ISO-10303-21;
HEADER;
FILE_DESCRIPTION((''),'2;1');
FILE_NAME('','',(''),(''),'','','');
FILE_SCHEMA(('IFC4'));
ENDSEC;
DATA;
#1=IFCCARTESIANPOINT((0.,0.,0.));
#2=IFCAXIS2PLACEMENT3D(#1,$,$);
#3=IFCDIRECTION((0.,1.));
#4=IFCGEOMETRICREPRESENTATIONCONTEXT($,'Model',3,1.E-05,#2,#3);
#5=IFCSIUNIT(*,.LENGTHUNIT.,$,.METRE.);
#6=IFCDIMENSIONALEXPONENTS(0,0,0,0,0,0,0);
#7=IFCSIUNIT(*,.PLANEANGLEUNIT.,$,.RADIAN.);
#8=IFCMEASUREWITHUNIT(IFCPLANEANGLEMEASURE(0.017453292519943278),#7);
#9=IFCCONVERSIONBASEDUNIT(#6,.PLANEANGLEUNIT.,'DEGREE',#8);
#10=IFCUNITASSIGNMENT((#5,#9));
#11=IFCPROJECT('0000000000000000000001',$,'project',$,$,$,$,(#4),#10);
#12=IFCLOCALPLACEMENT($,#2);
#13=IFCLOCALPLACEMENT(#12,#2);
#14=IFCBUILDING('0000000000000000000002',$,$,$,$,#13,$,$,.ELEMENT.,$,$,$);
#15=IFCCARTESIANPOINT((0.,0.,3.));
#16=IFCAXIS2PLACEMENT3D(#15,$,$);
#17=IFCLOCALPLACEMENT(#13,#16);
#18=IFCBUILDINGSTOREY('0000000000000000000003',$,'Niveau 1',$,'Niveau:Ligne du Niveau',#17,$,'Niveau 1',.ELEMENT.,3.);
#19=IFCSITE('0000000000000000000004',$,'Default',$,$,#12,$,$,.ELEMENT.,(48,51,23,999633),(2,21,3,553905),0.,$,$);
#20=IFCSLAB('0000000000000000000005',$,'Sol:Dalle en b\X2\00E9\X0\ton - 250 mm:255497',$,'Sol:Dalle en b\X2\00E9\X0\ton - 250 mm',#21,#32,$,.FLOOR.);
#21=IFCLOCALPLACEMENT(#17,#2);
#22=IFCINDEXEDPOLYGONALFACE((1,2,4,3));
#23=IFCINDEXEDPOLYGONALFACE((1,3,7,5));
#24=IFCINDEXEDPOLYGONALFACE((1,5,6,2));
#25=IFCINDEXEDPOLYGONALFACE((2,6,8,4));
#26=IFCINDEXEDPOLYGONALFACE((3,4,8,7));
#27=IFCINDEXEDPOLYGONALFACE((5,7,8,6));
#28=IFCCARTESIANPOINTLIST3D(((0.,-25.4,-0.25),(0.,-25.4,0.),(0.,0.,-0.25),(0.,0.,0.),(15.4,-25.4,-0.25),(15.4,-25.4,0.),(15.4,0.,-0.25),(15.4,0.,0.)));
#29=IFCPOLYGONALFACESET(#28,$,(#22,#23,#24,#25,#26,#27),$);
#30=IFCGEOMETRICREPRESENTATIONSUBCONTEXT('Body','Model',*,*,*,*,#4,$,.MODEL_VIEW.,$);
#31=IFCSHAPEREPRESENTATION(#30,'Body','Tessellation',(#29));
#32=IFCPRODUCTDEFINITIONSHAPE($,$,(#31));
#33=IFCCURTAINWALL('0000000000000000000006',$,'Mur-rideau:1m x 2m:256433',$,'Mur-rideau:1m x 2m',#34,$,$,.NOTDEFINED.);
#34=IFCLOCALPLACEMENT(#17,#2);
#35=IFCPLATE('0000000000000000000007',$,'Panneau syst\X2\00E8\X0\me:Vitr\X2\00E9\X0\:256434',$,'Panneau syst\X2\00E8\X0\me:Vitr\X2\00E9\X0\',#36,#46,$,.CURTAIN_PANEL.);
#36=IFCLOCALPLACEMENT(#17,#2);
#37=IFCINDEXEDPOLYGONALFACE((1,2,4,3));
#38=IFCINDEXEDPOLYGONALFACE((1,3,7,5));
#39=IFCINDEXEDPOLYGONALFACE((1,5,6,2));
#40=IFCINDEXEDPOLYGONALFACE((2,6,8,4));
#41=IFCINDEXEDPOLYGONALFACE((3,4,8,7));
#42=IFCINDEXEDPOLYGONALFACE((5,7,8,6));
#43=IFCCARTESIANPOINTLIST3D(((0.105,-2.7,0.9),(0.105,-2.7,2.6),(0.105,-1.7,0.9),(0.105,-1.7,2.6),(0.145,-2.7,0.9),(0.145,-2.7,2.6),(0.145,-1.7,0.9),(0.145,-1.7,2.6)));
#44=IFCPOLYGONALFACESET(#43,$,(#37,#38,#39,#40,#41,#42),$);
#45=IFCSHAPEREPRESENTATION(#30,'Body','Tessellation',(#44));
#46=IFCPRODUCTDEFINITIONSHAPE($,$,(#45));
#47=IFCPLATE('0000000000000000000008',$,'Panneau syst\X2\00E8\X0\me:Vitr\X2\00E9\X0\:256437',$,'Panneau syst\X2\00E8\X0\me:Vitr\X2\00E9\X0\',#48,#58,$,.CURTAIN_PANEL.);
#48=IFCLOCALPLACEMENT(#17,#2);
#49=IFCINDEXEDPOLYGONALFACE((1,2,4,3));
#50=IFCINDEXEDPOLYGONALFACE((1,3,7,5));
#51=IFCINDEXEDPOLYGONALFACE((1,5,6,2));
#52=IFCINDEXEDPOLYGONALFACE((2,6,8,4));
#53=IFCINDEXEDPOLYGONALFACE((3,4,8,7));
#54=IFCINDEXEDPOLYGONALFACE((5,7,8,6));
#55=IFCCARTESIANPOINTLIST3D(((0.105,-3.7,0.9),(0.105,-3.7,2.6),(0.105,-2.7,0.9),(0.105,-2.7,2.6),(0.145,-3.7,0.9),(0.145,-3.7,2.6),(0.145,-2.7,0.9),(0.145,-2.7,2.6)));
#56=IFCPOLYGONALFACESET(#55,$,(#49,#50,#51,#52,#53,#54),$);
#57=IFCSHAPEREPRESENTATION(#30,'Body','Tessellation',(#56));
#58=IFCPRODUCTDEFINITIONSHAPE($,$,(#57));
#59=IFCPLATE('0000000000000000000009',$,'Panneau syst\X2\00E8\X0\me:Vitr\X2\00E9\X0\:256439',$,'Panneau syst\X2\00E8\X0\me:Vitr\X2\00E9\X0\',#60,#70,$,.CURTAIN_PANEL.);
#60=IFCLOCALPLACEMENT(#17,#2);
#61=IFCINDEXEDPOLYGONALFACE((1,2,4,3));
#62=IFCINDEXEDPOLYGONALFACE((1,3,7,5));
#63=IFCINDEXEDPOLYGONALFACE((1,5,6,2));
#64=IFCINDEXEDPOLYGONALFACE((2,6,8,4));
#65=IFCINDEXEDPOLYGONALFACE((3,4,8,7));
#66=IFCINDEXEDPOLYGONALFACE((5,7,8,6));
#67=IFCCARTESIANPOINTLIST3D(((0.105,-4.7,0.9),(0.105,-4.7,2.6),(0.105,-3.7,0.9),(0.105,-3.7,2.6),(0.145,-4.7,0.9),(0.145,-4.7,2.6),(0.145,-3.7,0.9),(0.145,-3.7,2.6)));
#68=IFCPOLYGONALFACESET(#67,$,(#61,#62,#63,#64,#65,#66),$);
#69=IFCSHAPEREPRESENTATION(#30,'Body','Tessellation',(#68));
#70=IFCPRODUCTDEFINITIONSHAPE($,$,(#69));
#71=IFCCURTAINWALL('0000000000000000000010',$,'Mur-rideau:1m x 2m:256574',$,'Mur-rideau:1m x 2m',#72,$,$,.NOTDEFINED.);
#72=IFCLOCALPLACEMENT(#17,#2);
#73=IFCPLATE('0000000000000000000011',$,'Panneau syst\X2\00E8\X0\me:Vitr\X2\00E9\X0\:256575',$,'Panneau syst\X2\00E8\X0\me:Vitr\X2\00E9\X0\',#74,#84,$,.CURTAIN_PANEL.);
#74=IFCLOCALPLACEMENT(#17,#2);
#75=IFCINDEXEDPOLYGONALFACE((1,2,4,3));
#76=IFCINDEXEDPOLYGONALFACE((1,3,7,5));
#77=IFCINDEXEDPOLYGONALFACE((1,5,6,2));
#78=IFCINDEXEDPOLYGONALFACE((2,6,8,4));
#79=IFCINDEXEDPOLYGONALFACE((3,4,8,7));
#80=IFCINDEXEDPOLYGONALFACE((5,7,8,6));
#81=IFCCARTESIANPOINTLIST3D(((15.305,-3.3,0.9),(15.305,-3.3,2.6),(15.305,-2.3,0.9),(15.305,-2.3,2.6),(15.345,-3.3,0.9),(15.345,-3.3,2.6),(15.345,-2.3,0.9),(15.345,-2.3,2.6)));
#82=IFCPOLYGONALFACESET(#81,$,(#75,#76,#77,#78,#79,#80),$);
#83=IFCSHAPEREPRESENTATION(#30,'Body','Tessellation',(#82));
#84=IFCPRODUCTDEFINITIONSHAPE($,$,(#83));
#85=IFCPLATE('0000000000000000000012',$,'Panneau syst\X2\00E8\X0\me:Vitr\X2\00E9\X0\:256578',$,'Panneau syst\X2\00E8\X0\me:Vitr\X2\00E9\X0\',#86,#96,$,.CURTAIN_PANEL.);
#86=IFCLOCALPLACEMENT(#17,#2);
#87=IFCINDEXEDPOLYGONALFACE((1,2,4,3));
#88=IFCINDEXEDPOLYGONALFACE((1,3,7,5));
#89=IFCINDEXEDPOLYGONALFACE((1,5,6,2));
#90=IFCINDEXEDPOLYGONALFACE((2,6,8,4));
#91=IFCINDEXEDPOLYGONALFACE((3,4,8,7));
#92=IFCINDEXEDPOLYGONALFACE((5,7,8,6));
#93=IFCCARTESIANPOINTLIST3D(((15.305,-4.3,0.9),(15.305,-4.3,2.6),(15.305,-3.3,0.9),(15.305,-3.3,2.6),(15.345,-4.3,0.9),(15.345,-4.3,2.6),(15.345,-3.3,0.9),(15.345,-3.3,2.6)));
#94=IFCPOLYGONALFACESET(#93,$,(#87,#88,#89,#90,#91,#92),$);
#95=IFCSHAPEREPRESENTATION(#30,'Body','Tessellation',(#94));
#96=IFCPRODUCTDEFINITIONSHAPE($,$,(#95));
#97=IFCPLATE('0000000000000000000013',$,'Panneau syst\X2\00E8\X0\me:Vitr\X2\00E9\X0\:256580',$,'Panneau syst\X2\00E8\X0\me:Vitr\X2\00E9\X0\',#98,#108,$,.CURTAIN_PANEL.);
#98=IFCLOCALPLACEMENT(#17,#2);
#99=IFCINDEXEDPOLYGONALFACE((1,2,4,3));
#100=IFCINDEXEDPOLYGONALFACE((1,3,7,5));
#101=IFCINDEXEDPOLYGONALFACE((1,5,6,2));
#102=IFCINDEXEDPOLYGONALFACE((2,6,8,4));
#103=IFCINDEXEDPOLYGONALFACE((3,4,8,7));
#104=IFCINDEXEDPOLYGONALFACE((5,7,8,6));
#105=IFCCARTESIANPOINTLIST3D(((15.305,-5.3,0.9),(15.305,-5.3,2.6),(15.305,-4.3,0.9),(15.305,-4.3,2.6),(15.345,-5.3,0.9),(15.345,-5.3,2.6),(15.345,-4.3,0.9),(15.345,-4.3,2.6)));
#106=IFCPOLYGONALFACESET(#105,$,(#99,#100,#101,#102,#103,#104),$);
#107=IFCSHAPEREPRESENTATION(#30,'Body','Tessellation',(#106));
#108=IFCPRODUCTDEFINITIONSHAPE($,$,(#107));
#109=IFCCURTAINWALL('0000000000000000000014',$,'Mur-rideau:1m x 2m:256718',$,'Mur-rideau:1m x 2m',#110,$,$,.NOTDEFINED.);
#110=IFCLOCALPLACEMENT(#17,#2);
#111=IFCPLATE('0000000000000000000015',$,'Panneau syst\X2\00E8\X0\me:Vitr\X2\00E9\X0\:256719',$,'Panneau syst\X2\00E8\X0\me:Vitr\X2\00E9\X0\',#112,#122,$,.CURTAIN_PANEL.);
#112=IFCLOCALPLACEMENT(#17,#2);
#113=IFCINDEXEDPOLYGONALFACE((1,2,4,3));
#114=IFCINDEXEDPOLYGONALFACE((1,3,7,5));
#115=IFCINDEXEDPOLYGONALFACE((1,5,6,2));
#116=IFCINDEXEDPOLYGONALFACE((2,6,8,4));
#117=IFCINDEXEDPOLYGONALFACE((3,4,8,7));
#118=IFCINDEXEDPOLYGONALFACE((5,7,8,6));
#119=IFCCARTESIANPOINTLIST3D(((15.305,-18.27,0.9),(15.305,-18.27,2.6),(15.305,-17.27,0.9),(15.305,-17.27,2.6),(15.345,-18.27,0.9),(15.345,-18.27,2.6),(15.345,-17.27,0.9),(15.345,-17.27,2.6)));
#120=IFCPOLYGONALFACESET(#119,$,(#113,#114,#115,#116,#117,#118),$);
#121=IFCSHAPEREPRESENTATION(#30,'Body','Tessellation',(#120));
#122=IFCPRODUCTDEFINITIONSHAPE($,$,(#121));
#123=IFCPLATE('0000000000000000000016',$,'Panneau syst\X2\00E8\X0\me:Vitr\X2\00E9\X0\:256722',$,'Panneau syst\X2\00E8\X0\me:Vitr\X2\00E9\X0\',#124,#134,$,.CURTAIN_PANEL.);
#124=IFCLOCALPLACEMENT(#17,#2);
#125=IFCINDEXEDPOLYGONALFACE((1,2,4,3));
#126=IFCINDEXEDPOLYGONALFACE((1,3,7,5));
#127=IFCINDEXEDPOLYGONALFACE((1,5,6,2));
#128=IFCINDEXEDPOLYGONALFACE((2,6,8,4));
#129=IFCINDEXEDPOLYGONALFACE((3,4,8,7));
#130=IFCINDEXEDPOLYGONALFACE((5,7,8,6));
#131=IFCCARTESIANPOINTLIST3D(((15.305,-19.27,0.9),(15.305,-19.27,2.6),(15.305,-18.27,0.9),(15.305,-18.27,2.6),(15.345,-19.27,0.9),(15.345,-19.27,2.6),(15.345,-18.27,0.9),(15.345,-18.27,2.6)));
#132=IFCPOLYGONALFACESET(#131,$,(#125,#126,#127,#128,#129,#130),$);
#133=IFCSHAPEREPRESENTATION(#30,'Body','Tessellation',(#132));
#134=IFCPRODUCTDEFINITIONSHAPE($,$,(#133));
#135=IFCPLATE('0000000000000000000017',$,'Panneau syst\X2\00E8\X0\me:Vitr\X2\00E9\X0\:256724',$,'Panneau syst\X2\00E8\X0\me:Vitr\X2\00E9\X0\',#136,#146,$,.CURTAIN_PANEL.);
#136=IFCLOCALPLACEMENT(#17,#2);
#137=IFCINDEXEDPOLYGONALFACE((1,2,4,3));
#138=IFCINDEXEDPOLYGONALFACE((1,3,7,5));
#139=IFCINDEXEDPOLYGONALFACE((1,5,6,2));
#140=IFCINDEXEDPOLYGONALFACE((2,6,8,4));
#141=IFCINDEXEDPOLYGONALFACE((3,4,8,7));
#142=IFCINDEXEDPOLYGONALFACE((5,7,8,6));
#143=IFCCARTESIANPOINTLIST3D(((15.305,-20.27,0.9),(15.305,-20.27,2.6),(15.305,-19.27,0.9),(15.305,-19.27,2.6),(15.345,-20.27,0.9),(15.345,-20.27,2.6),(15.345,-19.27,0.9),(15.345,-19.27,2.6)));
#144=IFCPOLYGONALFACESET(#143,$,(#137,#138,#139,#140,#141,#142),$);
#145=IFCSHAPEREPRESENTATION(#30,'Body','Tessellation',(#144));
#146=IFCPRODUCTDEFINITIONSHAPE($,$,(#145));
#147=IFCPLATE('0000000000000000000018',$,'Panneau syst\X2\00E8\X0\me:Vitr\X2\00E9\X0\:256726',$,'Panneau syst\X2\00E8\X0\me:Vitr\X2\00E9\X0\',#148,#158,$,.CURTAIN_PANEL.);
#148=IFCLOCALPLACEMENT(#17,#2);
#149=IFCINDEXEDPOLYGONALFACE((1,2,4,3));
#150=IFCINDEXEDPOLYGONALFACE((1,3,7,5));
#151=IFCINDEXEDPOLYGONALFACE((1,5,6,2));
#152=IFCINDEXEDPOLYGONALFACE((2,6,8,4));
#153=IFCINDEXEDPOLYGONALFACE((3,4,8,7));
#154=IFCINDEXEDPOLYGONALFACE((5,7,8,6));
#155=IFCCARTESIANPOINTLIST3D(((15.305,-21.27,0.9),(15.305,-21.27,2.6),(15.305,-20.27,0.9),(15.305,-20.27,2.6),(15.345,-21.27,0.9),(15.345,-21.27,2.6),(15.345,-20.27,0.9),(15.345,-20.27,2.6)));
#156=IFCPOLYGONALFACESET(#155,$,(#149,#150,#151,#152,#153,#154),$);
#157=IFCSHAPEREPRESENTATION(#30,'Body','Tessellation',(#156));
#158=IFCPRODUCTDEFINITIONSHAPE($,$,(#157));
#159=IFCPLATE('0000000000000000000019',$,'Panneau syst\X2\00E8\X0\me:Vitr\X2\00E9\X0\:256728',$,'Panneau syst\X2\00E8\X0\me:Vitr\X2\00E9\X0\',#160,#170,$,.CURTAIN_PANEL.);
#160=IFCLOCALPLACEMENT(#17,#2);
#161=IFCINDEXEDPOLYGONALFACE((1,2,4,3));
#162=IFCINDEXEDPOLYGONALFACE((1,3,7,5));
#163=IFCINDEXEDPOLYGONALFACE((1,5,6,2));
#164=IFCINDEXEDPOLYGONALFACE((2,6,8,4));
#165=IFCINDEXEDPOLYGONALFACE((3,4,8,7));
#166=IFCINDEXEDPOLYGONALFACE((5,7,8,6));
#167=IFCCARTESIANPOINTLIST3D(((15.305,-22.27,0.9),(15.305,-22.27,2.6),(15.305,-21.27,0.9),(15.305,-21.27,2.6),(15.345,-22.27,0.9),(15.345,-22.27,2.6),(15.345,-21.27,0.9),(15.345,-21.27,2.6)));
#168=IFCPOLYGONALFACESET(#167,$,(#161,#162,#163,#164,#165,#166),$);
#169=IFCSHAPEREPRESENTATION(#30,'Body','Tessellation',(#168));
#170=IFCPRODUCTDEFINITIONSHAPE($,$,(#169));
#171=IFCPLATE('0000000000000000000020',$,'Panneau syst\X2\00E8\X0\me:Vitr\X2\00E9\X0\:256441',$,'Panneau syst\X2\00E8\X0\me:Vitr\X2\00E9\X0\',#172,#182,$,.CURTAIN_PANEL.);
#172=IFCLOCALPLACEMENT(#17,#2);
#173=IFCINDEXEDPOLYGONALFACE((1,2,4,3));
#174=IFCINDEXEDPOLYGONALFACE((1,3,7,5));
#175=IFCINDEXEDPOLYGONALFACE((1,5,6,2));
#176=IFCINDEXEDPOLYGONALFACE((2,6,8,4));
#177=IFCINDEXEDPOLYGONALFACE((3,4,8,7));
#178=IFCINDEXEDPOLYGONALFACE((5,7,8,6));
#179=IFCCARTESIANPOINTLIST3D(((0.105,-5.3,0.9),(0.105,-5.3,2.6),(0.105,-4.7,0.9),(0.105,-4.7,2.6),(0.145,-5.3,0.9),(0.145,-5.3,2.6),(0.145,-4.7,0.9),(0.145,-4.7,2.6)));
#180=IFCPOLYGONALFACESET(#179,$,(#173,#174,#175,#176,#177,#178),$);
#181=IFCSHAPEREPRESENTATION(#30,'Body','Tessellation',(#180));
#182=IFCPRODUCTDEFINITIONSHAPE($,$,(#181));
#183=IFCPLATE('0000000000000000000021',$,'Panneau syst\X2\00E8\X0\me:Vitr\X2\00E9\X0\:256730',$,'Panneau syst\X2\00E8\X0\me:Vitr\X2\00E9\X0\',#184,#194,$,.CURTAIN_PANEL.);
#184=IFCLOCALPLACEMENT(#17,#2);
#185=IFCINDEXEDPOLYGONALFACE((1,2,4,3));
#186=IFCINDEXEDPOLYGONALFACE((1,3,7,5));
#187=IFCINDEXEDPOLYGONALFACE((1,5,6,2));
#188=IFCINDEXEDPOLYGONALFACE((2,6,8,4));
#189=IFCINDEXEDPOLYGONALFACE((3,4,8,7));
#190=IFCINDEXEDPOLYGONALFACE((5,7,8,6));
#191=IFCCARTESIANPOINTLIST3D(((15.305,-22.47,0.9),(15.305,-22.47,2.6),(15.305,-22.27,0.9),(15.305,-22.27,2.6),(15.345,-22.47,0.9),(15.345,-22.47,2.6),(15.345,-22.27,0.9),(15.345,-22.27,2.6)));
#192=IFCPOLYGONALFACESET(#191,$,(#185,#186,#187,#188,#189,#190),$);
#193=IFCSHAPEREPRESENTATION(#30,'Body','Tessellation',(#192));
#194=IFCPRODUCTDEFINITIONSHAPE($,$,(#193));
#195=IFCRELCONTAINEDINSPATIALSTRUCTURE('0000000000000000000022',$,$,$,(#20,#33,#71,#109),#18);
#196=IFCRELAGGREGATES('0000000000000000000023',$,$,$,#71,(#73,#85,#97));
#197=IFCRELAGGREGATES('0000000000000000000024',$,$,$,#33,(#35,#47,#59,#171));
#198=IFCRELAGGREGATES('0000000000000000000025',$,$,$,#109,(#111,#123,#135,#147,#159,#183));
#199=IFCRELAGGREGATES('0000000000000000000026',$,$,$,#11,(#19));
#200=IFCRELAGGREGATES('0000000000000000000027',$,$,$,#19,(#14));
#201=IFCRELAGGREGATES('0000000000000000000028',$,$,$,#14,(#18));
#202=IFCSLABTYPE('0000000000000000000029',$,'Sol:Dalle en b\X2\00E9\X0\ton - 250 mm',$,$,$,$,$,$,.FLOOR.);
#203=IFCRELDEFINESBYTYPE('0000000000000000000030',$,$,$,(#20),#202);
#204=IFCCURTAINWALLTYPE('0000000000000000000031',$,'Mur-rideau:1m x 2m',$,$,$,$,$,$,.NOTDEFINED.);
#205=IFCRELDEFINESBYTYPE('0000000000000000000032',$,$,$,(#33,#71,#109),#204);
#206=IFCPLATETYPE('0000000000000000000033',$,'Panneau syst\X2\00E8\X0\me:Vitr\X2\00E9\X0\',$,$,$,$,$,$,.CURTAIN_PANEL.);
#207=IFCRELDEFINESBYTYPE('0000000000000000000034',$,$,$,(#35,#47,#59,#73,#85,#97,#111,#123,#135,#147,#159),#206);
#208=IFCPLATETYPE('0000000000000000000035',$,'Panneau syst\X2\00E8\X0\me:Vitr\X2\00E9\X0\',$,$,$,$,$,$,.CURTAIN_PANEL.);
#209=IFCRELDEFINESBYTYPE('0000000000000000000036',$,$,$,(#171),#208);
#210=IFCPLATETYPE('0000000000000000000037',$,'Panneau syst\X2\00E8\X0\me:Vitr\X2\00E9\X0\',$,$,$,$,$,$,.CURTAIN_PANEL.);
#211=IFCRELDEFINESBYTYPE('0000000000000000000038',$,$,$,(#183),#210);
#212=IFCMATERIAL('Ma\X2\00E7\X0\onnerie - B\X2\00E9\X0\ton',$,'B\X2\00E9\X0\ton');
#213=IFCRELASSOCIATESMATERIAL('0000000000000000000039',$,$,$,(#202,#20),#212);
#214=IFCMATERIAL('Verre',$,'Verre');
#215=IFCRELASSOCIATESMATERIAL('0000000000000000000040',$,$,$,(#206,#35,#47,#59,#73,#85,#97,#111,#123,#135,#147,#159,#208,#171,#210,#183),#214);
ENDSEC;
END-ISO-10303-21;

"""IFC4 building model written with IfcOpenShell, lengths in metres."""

from ifc_helpers import new_model, entity, si_unit, converted_unit, direction, frame, origin, place, context, subcontext, project, spatial, indexed_curve, outline, extrude, source, transform, mapped, material, type_object, type_shapes, element, aggregate, save


model = new_model("IFC4")

# Units and contexts
model_context = context("Model", 3, precision=1e-05, world=origin(), true_north=direction((0.0, 1.0)))
body_context = subcontext(model_context, "Body", "Model", "MODEL_VIEW")
ifc_project = project(units=[si_unit("LENGTHUNIT", "METRE"), converted_unit("PLANEANGLEUNIT", "DEGREE", entity("IfcPlaneAngleMeasure", 0.017453292519943278), si_unit("PLANEANGLEUNIT", "RADIAN"), dimensions=[0, 0, 0, 0, 0, 0, 0])], contexts=[model_context])

# Site, building, storey
site_placement = place(None, origin())
site = spatial("IfcSite", under=ifc_project, at=site_placement, Name="Default", CompositionType="ELEMENT", RefLatitude=(48, 51, 23, 999633), RefLongitude=(2, 21, 3, 553905), RefElevation=0.0)
building_placement = place(site_placement, origin())
building = spatial("IfcBuilding", under=site, at=building_placement, CompositionType="ELEMENT")
storey_placement = place(building_placement, frame((0.0, 0.0, 3.0)))
storey = spatial("IfcBuildingStorey", under=building, at=storey_placement, Name="Niveau 1", ObjectType="Niveau:Ligne du Niveau", LongName="Niveau 1", CompositionType="ELEMENT", Elevation=3.0)

# Slab
ifc_material_1 = material(Name="Maçonnerie - Béton", Category="Béton")
slab_type = type_object("IfcSlabType", Name="Sol:Dalle en béton - 250 mm", PredefinedType="FLOOR", material=ifc_material_1)
slab_placement = place(storey_placement, origin())
element("IfcSlab", 1, at=slab_placement, inside=storey, type_object=slab_type, material=ifc_material_1, Name="Sol:Dalle en béton - 250 mm:255497", ObjectType="Sol:Dalle en béton - 250 mm", PredefinedType="FLOOR", context=body_context, shape_type="SweptSolid", body=[
    extrude(outline(indexed_curve([(-12.7, -7.7), (12.7, -7.7), (12.7, 7.7), (-12.7, 7.7), (-12.7, -7.7)], self_intersect=False)), frame((7.7, -12.7, 0.0), z_axis=(0.0, 0.0, -1.0), x_axis=(0.0, 1.0, 0.0)), (0.0, 0.0, 1.0), 0.25),
])

# Curtain walls, plates
curtain_wall_type = type_object("IfcCurtainWallType", Name="Mur-rideau:1m x 2m", PredefinedType="NOTDEFINED")
curtain_wall_1_placement = place(storey_placement, frame((0.0, 0.0, -3.0)))
curtain_wall_1 = element("IfcCurtainWall", 2, at=curtain_wall_1_placement, inside=storey, type_object=curtain_wall_type, Name="Mur-rideau:1m x 2m:256433", ObjectType="Mur-rideau:1m x 2m", PredefinedType="NOTDEFINED")
ifc_material_2 = material(Name="Verre", Category="Verre")
plate_type_1 = type_object("IfcPlateType", Name="Panneau système:Vitré", PredefinedType="CURTAIN_PANEL", material=ifc_material_2)
shared_shape_1 = source(origin(), body_context, "Body", "SweptSolid", [
    extrude(outline(indexed_curve([(-0.02, -0.5), (0.02, -0.5), (0.02, 0.5), (-0.02, 0.5), (-0.02, -0.5)], self_intersect=False)), frame((0.5, 0.02, 0.0), z_axis=(0.0, 0.0, 1.0), x_axis=(0.0, 1.0, 0.0)), (0.0, 0.0, 1.0), 1.7),
])
type_shapes(plate_type_1, [shared_shape_1])
plate_1_placement = place(curtain_wall_1_placement, frame((0.105, -1.7, 3.9), z_axis=(0.0, 0.0, 1.0), x_axis=(0.0, -1.0, 0.0)))
plate_1 = element("IfcPlate", 3, at=plate_1_placement, type_object=plate_type_1, material=ifc_material_2, Name="Panneau système:Vitré:256434", ObjectType="Panneau système:Vitré", PredefinedType="CURTAIN_PANEL", context=body_context, shape_type="MappedRepresentation", body=[
    mapped(shared_shape_1, transform((0.0, 0.0, 0.0), scale=1.0)),
])
plate_2_placement = place(curtain_wall_1_placement, frame((0.105, -2.7, 3.9), z_axis=(0.0, 0.0, 1.0), x_axis=(0.0, -1.0, 0.0)))
plate_2 = element("IfcPlate", 4, at=plate_2_placement, type_object=plate_type_1, material=ifc_material_2, Name="Panneau système:Vitré:256437", ObjectType="Panneau système:Vitré", PredefinedType="CURTAIN_PANEL", context=body_context, shape_type="MappedRepresentation", body=[
    mapped(shared_shape_1, transform((0.0, 0.0, 0.0), scale=1.0)),
])
plate_3_placement = place(curtain_wall_1_placement, frame((0.105, -3.7, 3.9), z_axis=(0.0, 0.0, 1.0), x_axis=(0.0, -1.0, 0.0)))
plate_3 = element("IfcPlate", 5, at=plate_3_placement, type_object=plate_type_1, material=ifc_material_2, Name="Panneau système:Vitré:256439", ObjectType="Panneau système:Vitré", PredefinedType="CURTAIN_PANEL", context=body_context, shape_type="MappedRepresentation", body=[
    mapped(shared_shape_1, transform((0.0, 0.0, 0.0), scale=1.0)),
])
curtain_wall_2_placement = place(storey_placement, frame((0.0, 0.0, -3.0)))
curtain_wall_2 = element("IfcCurtainWall", 6, at=curtain_wall_2_placement, inside=storey, type_object=curtain_wall_type, Name="Mur-rideau:1m x 2m:256574", ObjectType="Mur-rideau:1m x 2m", PredefinedType="NOTDEFINED")
plate_4_placement = place(curtain_wall_2_placement, frame((15.305, -2.3, 3.9), z_axis=(0.0, 0.0, 1.0), x_axis=(0.0, -1.0, 0.0)))
plate_4 = element("IfcPlate", 7, at=plate_4_placement, type_object=plate_type_1, material=ifc_material_2, Name="Panneau système:Vitré:256575", ObjectType="Panneau système:Vitré", PredefinedType="CURTAIN_PANEL", context=body_context, shape_type="MappedRepresentation", body=[
    mapped(shared_shape_1, transform((0.0, 0.0, 0.0), scale=1.0)),
])
plate_5_placement = place(curtain_wall_2_placement, frame((15.305, -3.3, 3.9), z_axis=(0.0, 0.0, 1.0), x_axis=(0.0, -1.0, 0.0)))
plate_5 = element("IfcPlate", 8, at=plate_5_placement, type_object=plate_type_1, material=ifc_material_2, Name="Panneau système:Vitré:256578", ObjectType="Panneau système:Vitré", PredefinedType="CURTAIN_PANEL", context=body_context, shape_type="MappedRepresentation", body=[
    mapped(shared_shape_1, transform((0.0, 0.0, 0.0), scale=1.0)),
])
plate_6_placement = place(curtain_wall_2_placement, frame((15.305, -4.3, 3.9), z_axis=(0.0, 0.0, 1.0), x_axis=(0.0, -1.0, 0.0)))
plate_6 = element("IfcPlate", 9, at=plate_6_placement, type_object=plate_type_1, material=ifc_material_2, Name="Panneau système:Vitré:256580", ObjectType="Panneau système:Vitré", PredefinedType="CURTAIN_PANEL", context=body_context, shape_type="MappedRepresentation", body=[
    mapped(shared_shape_1, transform((0.0, 0.0, 0.0), scale=1.0)),
])
aggregate(curtain_wall_2, [plate_4, plate_5, plate_6])
curtain_wall_3_placement = place(storey_placement, frame((0.0, 0.0, -3.0)))
curtain_wall_3 = element("IfcCurtainWall", 10, at=curtain_wall_3_placement, inside=storey, type_object=curtain_wall_type, Name="Mur-rideau:1m x 2m:256718", ObjectType="Mur-rideau:1m x 2m", PredefinedType="NOTDEFINED")
plate_7_placement = place(curtain_wall_3_placement, frame((15.305, -17.27, 3.9), z_axis=(0.0, 0.0, 1.0), x_axis=(0.0, -1.0, 0.0)))
plate_7 = element("IfcPlate", 11, at=plate_7_placement, type_object=plate_type_1, material=ifc_material_2, Name="Panneau système:Vitré:256719", ObjectType="Panneau système:Vitré", PredefinedType="CURTAIN_PANEL", context=body_context, shape_type="MappedRepresentation", body=[
    mapped(shared_shape_1, transform((0.0, 0.0, 0.0), scale=1.0)),
])
plate_8_placement = place(curtain_wall_3_placement, frame((15.305, -18.27, 3.9), z_axis=(0.0, 0.0, 1.0), x_axis=(0.0, -1.0, 0.0)))
plate_8 = element("IfcPlate", 12, at=plate_8_placement, type_object=plate_type_1, material=ifc_material_2, Name="Panneau système:Vitré:256722", ObjectType="Panneau système:Vitré", PredefinedType="CURTAIN_PANEL", context=body_context, shape_type="MappedRepresentation", body=[
    mapped(shared_shape_1, transform((0.0, 0.0, 0.0), scale=1.0)),
])
plate_9_placement = place(curtain_wall_3_placement, frame((15.305, -19.27, 3.9), z_axis=(0.0, 0.0, 1.0), x_axis=(0.0, -1.0, 0.0)))
plate_9 = element("IfcPlate", 13, at=plate_9_placement, type_object=plate_type_1, material=ifc_material_2, Name="Panneau système:Vitré:256724", ObjectType="Panneau système:Vitré", PredefinedType="CURTAIN_PANEL", context=body_context, shape_type="MappedRepresentation", body=[
    mapped(shared_shape_1, transform((0.0, 0.0, 0.0), scale=1.0)),
])
plate_10_placement = place(curtain_wall_3_placement, frame((15.305, -20.27, 3.9), z_axis=(0.0, 0.0, 1.0), x_axis=(0.0, -1.0, 0.0)))
plate_10 = element("IfcPlate", 14, at=plate_10_placement, type_object=plate_type_1, material=ifc_material_2, Name="Panneau système:Vitré:256726", ObjectType="Panneau système:Vitré", PredefinedType="CURTAIN_PANEL", context=body_context, shape_type="MappedRepresentation", body=[
    mapped(shared_shape_1, transform((0.0, 0.0, 0.0), scale=1.0)),
])
plate_11_placement = place(curtain_wall_3_placement, frame((15.305, -21.27, 3.9), z_axis=(0.0, 0.0, 1.0), x_axis=(0.0, -1.0, 0.0)))
plate_11 = element("IfcPlate", 15, at=plate_11_placement, type_object=plate_type_1, material=ifc_material_2, Name="Panneau système:Vitré:256728", ObjectType="Panneau système:Vitré", PredefinedType="CURTAIN_PANEL", context=body_context, shape_type="MappedRepresentation", body=[
    mapped(shared_shape_1, transform((0.0, 0.0, 0.0), scale=1.0)),
])

# Plates
plate_type_2 = type_object("IfcPlateType", Name="Panneau système:Vitré", PredefinedType="CURTAIN_PANEL", material=ifc_material_2)
shared_shape_2 = source(origin(), body_context, "Body", "SweptSolid", [
    extrude(outline(indexed_curve([(-0.02, -0.3), (0.02, -0.3), (0.02, 0.3), (-0.02, 0.3), (-0.02, -0.3)], self_intersect=False)), frame((0.3, 0.02, 0.0), z_axis=(0.0, 0.0, 1.0), x_axis=(0.0, 1.0, 0.0)), (0.0, 0.0, 1.0), 1.7),
])
type_shapes(plate_type_2, [shared_shape_2])
plate_12_placement = place(curtain_wall_1_placement, frame((0.105, -4.7, 3.9), z_axis=(0.0, 0.0, 1.0), x_axis=(0.0, -1.0, 0.0)))
plate_12 = element("IfcPlate", 16, at=plate_12_placement, type_object=plate_type_2, material=ifc_material_2, Name="Panneau système:Vitré:256441", ObjectType="Panneau système:Vitré", PredefinedType="CURTAIN_PANEL", context=body_context, shape_type="MappedRepresentation", body=[
    mapped(shared_shape_2, transform((0.0, 0.0, 0.0), scale=1.0)),
])
aggregate(curtain_wall_1, [plate_1, plate_2, plate_3, plate_12])
plate_type_3 = type_object("IfcPlateType", Name="Panneau système:Vitré", PredefinedType="CURTAIN_PANEL", material=ifc_material_2)
shared_shape_3 = source(origin(), body_context, "Body", "SweptSolid", [
    extrude(outline(indexed_curve([(-0.02, -0.1), (0.02, -0.1), (0.02, 0.1), (-0.02, 0.1), (-0.02, -0.1)], self_intersect=False)), frame((0.1, 0.02, 0.0), z_axis=(0.0, 0.0, 1.0), x_axis=(0.0, 1.0, 0.0)), (0.0, 0.0, 1.0), 1.7),
])
type_shapes(plate_type_3, [shared_shape_3])
plate_13_placement = place(curtain_wall_3_placement, frame((15.305, -22.27, 3.9), z_axis=(0.0, 0.0, 1.0), x_axis=(0.0, -1.0, 0.0)))
plate_13 = element("IfcPlate", 17, at=plate_13_placement, type_object=plate_type_3, material=ifc_material_2, Name="Panneau système:Vitré:256730", ObjectType="Panneau système:Vitré", PredefinedType="CURTAIN_PANEL", context=body_context, shape_type="MappedRepresentation", body=[
    mapped(shared_shape_3, transform((0.0, 0.0, 0.0), scale=1.0)),
])
aggregate(curtain_wall_3, [plate_7, plate_8, plate_9, plate_10, plate_11, plate_13])

save(model, "model.ifc")
